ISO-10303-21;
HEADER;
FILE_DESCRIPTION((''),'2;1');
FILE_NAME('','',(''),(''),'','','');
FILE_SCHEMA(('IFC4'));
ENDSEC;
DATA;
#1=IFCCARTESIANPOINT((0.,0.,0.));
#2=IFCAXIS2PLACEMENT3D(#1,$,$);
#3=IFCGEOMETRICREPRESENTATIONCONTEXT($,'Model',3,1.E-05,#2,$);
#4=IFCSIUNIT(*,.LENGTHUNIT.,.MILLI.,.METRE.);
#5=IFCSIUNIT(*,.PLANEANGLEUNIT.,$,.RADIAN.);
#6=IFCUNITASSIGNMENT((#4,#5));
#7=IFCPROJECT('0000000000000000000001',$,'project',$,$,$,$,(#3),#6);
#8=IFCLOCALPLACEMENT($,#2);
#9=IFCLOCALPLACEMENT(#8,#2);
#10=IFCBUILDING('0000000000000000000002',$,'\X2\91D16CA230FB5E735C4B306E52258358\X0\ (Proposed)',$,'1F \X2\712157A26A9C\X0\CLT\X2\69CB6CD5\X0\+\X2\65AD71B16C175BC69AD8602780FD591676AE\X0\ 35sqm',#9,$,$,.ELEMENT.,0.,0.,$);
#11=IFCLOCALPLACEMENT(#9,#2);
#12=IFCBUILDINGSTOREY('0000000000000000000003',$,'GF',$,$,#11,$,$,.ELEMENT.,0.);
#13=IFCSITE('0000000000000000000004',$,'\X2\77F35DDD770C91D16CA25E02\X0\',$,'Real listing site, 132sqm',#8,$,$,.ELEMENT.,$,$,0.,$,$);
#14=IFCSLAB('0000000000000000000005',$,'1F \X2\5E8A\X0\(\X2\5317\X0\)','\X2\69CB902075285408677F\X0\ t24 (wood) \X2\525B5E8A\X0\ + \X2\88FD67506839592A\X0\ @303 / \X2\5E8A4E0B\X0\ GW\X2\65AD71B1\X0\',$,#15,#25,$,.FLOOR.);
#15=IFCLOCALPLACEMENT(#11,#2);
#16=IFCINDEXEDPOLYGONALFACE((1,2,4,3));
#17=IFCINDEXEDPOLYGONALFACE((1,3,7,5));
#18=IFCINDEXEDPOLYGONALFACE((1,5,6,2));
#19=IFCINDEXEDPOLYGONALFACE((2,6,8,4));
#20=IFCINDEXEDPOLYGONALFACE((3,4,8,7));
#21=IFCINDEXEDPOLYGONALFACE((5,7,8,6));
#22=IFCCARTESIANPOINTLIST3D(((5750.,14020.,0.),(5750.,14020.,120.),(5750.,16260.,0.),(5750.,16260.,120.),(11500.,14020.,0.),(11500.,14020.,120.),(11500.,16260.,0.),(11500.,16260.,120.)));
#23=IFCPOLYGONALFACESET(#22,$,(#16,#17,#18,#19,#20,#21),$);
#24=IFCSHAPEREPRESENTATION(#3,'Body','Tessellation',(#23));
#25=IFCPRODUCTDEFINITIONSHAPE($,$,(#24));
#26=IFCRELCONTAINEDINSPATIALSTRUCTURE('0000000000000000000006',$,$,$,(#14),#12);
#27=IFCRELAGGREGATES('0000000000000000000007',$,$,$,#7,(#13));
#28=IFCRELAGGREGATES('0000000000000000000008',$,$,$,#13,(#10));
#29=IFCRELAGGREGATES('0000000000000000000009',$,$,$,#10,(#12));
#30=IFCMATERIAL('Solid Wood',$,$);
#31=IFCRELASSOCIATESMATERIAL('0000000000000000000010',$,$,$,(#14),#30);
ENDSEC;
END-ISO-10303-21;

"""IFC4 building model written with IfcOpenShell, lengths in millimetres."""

from ifc_helpers import new_model, si_unit, frame, frame_2d, origin, place, context, project, spatial, rectangle, extrude, material, element, save


model = new_model("IFC4")

# Units and contexts
model_context = context("Model", 3, precision=1e-05, world=origin())
ifc_project = project(units=[si_unit("LENGTHUNIT", "METRE", prefix="MILLI"), si_unit("PLANEANGLEUNIT", "RADIAN")], contexts=[model_context])

# Site, building, storey
site_placement = place(None, origin())
site = spatial("IfcSite", under=ifc_project, at=site_placement, Name="石川県金沢市", ObjectType="Real listing site, 132sqm", CompositionType="ELEMENT", RefElevation=0.0)
building_placement = place(site_placement, origin())
building = spatial("IfcBuilding", under=site, at=building_placement, Name="金沢・平屋の別荘 (Proposed)", ObjectType="1F 無垢檜CLT構法+断熱気密高性能外皮 35sqm", CompositionType="ELEMENT", ElevationOfRefHeight=0.0, ElevationOfTerrain=0.0)
storey_placement = place(building_placement, origin())
storey = spatial("IfcBuildingStorey", under=building, at=storey_placement, Name="GF", CompositionType="ELEMENT", Elevation=0.0)

# Shared definitions
ifc_material_1 = material(Name="Solid Wood")

# Slab
slab_1_placement = place(storey_placement, frame((2875.0, 7010.0, 0.0)))
element("IfcSlab", 1, at=slab_1_placement, inside=storey, material=ifc_material_1, Name="1F 床(北)", Description="構造用合板 t24 (wood) 剛床 + 製材根太 @303 / 床下 GW断熱", PredefinedType="FLOOR", context=model_context, shape_type="SweptSolid", body=[
    extrude(rectangle(XDim=5750.0, YDim=2240.0, at=frame_2d((2875.0, 1120.0))), frame((2875.0, 7010.0, 0.0)), (0.0, 0.0, 1.0), 120.0),
])

save(model, "model.ifc")
